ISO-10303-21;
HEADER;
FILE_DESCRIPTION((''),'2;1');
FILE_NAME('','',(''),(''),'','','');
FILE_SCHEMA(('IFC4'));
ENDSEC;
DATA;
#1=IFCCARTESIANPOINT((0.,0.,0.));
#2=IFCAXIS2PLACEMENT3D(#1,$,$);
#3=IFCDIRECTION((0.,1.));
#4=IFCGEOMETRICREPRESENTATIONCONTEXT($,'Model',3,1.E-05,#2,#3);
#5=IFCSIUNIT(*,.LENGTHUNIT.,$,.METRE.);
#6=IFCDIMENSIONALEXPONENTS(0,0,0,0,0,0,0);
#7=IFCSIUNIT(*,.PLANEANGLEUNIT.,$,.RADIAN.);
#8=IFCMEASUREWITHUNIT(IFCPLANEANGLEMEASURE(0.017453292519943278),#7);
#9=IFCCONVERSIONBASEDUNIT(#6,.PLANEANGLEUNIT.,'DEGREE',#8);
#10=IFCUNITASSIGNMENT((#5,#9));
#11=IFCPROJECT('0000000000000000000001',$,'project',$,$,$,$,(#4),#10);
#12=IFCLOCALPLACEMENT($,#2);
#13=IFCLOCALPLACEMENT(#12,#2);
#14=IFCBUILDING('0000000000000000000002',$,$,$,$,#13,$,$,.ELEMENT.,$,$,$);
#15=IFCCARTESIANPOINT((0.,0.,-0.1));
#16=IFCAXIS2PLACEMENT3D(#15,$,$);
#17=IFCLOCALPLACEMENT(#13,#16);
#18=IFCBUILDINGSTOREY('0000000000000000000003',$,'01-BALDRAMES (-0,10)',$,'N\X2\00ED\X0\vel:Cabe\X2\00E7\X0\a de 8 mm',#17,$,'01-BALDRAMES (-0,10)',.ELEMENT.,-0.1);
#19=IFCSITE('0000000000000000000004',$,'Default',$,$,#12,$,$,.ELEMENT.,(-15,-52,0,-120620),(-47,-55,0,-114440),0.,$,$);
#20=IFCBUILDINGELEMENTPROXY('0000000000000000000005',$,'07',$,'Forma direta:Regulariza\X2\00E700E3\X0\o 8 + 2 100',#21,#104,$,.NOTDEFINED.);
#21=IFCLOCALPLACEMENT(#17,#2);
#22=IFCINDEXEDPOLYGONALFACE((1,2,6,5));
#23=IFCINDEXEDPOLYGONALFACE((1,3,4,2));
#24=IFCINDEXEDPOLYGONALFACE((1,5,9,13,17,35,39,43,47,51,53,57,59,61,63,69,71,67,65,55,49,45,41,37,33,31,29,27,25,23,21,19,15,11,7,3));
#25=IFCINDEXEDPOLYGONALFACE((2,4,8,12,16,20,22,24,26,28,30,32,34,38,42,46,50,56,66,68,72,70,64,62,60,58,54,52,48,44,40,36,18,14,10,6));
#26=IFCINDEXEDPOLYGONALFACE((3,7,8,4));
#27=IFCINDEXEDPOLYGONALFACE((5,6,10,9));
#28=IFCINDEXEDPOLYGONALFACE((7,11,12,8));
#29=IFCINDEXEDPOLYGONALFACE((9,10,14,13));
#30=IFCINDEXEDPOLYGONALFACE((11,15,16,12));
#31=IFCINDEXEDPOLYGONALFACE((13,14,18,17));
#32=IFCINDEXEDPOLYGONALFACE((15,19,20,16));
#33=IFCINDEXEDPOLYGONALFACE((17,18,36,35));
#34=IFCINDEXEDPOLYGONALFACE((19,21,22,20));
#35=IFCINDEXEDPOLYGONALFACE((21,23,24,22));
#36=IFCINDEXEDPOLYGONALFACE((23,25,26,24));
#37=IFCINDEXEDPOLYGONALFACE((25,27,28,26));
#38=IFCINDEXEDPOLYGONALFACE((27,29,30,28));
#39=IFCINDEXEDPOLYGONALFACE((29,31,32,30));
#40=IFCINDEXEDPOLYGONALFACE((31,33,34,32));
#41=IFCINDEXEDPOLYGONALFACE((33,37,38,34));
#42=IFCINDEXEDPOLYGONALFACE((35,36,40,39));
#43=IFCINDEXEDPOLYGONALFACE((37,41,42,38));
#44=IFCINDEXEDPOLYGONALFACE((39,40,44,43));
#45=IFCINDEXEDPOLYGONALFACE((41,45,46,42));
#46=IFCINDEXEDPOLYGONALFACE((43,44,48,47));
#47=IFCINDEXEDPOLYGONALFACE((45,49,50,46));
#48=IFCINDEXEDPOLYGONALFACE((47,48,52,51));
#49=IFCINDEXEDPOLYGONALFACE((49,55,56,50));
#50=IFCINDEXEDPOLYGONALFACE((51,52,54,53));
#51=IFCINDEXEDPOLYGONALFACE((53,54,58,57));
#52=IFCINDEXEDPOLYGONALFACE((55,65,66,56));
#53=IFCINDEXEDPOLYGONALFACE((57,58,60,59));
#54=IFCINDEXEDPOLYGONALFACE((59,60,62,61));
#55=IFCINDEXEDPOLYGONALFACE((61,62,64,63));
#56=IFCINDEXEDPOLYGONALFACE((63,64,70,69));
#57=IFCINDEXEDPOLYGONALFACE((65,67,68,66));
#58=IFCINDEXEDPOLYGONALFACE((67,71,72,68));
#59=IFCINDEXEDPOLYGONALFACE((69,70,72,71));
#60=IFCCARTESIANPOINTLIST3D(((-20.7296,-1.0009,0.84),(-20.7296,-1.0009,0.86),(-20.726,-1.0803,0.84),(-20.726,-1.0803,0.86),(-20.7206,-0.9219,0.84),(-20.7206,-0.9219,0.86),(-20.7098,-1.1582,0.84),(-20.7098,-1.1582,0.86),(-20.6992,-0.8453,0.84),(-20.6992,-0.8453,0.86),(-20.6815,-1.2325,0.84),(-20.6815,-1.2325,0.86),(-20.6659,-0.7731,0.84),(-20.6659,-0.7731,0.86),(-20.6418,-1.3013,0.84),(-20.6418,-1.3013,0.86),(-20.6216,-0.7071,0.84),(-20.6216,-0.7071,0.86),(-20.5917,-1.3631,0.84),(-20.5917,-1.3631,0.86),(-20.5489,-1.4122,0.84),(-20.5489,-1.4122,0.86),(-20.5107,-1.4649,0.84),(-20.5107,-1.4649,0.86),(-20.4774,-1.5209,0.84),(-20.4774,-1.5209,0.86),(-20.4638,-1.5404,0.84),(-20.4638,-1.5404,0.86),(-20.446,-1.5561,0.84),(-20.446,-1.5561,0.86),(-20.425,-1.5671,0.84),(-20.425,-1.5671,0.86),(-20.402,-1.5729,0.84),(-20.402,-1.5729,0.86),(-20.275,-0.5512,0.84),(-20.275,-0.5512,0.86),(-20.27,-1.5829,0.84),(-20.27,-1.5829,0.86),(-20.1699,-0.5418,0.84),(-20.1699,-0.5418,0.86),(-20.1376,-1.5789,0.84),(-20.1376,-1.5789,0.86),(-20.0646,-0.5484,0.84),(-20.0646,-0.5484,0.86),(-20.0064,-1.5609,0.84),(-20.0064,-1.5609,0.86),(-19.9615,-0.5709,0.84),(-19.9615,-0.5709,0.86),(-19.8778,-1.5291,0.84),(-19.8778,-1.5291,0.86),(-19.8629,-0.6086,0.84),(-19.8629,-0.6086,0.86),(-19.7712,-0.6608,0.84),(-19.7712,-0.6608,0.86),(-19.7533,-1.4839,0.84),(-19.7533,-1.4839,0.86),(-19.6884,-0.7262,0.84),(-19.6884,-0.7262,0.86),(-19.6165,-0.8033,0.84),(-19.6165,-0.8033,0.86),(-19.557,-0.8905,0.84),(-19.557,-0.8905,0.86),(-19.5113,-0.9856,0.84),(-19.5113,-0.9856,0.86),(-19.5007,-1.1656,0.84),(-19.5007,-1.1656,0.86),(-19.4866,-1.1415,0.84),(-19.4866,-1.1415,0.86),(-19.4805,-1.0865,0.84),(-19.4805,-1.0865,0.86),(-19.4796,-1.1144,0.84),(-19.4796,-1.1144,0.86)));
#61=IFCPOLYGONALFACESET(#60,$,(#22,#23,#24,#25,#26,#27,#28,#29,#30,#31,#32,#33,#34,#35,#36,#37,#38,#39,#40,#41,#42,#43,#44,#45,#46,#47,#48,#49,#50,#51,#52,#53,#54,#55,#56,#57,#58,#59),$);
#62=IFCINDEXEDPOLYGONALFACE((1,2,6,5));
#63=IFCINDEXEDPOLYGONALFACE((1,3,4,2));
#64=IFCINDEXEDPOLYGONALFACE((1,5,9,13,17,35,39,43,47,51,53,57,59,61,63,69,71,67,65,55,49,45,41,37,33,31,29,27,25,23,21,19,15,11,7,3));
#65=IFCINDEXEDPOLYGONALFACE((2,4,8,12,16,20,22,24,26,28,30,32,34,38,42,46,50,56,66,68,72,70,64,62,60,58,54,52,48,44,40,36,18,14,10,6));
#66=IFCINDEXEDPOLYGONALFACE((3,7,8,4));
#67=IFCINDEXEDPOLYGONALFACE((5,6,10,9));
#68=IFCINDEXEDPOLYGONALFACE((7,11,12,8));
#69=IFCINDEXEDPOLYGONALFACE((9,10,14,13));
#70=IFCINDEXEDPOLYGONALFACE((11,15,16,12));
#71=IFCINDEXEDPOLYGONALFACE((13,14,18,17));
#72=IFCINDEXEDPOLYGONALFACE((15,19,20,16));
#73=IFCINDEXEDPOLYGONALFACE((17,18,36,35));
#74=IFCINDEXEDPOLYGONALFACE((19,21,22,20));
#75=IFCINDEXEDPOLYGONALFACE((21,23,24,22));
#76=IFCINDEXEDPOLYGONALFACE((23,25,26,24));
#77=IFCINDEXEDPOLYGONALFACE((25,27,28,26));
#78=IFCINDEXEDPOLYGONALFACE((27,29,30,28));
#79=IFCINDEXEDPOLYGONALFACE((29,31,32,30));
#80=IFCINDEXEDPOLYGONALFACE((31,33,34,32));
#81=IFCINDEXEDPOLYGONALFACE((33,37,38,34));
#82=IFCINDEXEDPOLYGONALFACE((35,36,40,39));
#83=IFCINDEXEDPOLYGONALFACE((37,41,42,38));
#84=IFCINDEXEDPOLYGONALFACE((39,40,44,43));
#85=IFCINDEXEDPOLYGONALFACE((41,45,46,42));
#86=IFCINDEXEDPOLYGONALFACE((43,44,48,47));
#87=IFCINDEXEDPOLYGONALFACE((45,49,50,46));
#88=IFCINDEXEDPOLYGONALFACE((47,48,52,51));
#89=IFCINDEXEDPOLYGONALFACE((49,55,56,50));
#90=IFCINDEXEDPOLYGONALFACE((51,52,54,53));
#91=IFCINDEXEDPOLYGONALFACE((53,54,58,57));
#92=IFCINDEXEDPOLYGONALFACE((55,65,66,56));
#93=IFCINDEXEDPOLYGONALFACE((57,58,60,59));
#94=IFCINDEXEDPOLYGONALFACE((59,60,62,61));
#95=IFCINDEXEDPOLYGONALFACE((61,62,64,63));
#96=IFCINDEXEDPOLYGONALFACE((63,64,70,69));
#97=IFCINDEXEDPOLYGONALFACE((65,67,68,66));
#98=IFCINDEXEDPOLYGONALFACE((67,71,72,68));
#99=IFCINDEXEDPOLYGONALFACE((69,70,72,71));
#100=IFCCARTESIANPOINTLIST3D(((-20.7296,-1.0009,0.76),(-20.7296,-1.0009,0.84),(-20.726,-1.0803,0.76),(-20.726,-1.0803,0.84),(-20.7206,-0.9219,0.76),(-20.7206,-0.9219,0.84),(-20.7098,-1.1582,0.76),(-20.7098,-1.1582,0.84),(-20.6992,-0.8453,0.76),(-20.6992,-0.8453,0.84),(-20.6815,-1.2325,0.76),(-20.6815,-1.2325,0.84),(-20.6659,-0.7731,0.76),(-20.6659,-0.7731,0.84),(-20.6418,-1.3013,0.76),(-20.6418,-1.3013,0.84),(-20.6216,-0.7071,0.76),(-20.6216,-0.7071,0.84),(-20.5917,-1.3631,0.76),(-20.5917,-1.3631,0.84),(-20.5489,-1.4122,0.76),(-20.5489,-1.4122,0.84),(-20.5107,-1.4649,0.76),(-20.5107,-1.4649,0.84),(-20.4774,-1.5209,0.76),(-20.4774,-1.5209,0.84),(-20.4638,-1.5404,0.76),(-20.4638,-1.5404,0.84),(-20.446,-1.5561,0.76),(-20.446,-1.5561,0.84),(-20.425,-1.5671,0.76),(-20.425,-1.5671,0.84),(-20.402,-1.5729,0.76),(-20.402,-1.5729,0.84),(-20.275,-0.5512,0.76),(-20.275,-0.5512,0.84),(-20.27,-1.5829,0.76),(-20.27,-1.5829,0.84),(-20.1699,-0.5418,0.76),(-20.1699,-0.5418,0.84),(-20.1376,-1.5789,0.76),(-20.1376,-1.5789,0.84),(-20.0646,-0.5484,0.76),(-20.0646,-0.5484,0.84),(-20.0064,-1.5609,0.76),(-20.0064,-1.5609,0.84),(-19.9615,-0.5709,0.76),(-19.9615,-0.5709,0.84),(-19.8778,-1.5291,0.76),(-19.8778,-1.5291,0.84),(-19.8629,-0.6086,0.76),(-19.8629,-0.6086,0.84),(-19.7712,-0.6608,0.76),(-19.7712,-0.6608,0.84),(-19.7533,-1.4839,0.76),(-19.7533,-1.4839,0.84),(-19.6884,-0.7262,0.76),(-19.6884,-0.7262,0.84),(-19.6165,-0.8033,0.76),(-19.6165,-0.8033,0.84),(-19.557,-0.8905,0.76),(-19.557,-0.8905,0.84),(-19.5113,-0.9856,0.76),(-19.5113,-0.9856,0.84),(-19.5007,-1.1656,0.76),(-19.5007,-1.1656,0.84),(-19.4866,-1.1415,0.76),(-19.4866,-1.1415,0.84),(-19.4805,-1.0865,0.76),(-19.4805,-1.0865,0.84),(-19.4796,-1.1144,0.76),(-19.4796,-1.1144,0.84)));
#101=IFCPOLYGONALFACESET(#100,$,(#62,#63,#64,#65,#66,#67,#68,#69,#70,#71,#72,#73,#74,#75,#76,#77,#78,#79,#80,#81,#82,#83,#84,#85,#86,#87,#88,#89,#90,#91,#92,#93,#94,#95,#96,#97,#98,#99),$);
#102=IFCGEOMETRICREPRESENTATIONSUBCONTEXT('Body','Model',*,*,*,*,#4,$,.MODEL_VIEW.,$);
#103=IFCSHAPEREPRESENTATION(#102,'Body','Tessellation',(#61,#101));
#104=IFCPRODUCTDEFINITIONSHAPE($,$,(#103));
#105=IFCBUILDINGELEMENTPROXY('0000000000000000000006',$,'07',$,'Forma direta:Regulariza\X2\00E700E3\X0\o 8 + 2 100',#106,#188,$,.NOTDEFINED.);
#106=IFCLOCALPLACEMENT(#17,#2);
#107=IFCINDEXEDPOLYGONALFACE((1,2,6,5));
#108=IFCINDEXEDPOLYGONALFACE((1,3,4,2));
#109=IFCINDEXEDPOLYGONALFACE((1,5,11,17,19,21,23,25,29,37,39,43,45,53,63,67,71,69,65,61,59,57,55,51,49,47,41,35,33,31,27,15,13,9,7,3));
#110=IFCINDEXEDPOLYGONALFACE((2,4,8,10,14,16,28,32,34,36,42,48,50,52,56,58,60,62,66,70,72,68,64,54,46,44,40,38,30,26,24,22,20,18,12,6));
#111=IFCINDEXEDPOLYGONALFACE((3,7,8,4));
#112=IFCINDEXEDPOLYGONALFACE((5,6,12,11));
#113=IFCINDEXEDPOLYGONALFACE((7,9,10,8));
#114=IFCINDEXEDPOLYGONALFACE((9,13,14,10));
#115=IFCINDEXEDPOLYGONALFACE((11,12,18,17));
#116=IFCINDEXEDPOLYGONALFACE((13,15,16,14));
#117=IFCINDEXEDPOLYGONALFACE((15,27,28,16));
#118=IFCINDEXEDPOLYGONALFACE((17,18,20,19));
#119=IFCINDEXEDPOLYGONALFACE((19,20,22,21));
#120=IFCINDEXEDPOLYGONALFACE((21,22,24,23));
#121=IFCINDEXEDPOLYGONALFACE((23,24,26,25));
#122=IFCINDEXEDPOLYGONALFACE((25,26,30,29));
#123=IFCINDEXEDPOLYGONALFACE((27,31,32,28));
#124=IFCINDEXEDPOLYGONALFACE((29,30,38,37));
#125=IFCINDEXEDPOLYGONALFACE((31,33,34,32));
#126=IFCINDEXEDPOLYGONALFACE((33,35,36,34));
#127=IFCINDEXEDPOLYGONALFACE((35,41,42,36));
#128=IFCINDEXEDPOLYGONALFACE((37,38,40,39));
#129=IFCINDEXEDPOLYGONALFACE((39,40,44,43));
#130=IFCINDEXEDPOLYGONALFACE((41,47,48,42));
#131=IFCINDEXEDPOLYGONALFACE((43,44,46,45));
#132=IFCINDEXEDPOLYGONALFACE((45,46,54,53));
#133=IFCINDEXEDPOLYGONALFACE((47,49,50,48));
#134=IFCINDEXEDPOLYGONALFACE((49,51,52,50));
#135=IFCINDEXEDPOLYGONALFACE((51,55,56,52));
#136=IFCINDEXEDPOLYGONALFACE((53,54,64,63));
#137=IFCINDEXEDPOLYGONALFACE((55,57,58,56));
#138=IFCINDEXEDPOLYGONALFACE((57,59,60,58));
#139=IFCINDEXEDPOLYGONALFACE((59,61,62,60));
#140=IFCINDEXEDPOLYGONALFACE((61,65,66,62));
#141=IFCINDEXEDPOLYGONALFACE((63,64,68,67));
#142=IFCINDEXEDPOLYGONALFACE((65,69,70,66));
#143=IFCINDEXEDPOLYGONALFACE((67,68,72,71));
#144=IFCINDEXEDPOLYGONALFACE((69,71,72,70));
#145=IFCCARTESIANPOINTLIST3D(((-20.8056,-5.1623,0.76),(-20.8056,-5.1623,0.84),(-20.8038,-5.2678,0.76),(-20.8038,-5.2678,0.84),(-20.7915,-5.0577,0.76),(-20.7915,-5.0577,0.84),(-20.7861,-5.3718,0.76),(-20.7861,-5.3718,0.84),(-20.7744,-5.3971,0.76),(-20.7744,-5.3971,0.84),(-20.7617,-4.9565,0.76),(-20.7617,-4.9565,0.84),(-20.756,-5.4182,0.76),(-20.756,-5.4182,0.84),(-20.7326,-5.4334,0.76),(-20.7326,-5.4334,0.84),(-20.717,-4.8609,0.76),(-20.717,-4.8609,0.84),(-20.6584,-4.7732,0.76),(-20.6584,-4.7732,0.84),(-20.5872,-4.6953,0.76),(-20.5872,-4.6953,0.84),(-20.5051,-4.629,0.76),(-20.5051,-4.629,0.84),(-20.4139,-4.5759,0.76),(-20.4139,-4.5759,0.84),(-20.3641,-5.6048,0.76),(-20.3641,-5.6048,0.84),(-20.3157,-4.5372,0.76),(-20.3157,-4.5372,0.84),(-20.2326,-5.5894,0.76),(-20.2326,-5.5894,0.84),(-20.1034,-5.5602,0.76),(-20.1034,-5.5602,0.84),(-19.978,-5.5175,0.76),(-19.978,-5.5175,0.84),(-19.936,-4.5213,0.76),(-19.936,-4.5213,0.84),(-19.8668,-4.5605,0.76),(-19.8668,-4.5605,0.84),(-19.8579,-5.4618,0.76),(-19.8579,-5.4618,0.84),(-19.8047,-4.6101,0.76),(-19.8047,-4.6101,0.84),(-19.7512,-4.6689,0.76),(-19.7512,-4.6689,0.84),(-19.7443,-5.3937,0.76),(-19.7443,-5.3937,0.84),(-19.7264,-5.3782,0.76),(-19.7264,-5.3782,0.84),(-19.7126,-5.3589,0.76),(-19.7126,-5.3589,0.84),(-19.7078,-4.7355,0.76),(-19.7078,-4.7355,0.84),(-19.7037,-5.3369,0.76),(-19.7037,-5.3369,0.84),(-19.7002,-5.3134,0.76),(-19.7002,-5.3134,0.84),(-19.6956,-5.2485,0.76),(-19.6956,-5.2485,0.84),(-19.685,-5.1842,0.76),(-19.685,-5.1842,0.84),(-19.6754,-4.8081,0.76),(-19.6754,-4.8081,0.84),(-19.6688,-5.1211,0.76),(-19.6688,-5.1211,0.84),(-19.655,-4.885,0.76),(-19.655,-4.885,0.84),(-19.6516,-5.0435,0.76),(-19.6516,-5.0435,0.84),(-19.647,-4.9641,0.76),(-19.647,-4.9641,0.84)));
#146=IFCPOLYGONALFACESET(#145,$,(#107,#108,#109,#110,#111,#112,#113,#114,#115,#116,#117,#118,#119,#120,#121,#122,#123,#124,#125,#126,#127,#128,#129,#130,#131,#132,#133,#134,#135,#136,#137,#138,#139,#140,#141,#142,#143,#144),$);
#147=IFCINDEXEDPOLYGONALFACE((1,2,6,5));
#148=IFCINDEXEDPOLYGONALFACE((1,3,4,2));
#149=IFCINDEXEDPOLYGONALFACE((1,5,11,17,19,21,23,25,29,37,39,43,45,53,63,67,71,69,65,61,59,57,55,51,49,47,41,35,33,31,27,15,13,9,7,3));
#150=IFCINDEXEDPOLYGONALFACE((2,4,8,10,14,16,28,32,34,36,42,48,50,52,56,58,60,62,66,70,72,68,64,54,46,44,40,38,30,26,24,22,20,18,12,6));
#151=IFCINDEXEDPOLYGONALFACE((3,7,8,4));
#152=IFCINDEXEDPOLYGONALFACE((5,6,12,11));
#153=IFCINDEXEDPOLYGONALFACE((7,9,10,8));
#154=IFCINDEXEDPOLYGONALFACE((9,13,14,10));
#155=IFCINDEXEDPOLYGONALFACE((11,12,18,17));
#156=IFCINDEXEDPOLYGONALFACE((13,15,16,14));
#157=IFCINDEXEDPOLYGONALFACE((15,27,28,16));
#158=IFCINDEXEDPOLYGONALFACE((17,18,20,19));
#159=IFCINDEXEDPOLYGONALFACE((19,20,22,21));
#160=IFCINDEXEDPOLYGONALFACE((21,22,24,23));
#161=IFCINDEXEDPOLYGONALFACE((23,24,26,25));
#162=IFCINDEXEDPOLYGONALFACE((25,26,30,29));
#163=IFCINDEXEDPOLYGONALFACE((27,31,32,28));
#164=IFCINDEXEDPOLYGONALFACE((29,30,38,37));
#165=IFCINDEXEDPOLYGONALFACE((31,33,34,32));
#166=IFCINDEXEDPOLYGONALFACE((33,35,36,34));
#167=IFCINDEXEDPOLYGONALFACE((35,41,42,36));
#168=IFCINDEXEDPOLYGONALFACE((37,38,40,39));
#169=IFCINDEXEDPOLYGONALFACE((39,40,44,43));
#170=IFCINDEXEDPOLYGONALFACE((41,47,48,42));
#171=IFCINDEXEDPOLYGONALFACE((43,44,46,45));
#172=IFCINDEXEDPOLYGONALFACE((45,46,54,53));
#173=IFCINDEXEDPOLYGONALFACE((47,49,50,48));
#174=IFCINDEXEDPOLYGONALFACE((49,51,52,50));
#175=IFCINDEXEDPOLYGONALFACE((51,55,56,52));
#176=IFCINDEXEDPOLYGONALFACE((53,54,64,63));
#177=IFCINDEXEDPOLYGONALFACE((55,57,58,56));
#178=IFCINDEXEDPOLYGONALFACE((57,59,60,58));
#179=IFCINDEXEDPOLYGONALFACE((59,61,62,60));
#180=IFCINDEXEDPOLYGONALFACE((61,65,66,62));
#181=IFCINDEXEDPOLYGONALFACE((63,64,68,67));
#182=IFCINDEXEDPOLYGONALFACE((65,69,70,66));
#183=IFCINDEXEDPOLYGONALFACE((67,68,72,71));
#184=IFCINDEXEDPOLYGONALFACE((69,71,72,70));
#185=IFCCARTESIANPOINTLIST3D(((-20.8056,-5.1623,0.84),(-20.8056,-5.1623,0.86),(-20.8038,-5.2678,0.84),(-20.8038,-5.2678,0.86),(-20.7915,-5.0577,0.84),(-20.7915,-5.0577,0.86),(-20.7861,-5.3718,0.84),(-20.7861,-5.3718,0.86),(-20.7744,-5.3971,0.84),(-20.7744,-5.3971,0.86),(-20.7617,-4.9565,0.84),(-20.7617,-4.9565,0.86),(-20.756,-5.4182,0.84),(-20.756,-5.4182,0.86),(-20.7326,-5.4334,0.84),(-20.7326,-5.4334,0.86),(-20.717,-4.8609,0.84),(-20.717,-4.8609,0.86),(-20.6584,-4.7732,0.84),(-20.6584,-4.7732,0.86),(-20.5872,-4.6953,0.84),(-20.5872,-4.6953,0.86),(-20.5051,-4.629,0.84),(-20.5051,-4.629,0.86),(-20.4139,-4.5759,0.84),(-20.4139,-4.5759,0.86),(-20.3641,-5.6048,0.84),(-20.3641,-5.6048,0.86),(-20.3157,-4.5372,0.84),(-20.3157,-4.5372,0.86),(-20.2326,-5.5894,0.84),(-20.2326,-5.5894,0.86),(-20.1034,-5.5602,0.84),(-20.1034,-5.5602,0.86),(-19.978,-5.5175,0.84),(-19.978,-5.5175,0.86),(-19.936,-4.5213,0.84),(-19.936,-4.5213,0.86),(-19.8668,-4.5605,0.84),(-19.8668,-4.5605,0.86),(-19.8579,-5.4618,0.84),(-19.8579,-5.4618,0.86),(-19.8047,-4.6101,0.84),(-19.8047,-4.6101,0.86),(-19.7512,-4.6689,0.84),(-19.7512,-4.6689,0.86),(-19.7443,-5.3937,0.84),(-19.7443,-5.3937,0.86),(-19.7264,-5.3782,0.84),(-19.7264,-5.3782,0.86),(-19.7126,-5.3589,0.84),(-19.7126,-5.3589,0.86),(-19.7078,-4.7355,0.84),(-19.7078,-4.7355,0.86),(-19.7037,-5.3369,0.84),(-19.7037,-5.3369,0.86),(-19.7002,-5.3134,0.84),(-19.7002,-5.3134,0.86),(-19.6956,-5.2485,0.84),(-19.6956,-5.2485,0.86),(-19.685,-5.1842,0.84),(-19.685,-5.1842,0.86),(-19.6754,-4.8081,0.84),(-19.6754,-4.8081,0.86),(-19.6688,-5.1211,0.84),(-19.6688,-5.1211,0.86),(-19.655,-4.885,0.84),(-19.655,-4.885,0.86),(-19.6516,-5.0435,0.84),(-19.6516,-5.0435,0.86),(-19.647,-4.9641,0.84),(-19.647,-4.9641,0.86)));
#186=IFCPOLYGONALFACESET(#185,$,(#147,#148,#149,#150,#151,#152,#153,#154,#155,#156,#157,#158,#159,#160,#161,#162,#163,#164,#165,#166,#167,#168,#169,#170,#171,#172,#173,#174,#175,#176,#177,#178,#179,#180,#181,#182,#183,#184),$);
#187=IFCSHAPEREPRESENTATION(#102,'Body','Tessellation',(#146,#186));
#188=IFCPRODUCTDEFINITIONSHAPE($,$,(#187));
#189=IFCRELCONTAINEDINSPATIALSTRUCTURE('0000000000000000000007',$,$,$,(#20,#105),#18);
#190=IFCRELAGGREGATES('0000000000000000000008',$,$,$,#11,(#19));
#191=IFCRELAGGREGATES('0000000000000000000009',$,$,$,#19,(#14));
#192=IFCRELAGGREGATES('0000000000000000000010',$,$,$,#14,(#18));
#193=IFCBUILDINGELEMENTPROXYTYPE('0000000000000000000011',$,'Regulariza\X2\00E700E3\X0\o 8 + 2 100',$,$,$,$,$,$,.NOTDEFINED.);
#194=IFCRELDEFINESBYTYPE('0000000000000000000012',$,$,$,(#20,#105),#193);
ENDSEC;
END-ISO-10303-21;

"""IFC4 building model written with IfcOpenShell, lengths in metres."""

from ifc_helpers import new_model, entity, si_unit, converted_unit, direction, frame, origin, place, context, subcontext, project, spatial, line, arc, indexed_curve, outline, extrude, type_object, element, save


model = new_model("IFC4")

# Units and contexts
model_context = context("Model", 3, precision=1e-05, world=origin(), true_north=direction((0.0, 1.0)))
body_context = subcontext(model_context, "Body", "Model", "MODEL_VIEW")
ifc_project = project(units=[si_unit("LENGTHUNIT", "METRE"), converted_unit("PLANEANGLEUNIT", "DEGREE", entity("IfcPlaneAngleMeasure", 0.017453292519943278), si_unit("PLANEANGLEUNIT", "RADIAN"), dimensions=[0, 0, 0, 0, 0, 0, 0])], contexts=[model_context])

# Site, building, storey
site_placement = place(None, origin())
site = spatial("IfcSite", under=ifc_project, at=site_placement, Name="Default", CompositionType="ELEMENT", RefLatitude=(-15, -52, 0, -120620), RefLongitude=(-47, -55, 0, -114440), RefElevation=0.0)
building_placement = place(site_placement, origin())
building = spatial("IfcBuilding", under=site, at=building_placement, CompositionType="ELEMENT")
storey_placement = place(building_placement, frame((0.0, 0.0, -0.1)))
storey = spatial("IfcBuildingStorey", under=building, at=storey_placement, Name="01-BALDRAMES (-0,10)", ObjectType="Nível:Cabeça de 8 mm", LongName="01-BALDRAMES (-0,10)", CompositionType="ELEMENT", Elevation=-0.1)

# Building element proxies
building_element_proxy_type_1 = type_object("IfcBuildingElementProxyType", Name="Regularização 8 + 2 100", PredefinedType="NOTDEFINED")
proxy_1_placement = place(storey_placement, origin())
element("IfcBuildingElementProxy", 1, at=proxy_1_placement, inside=storey, type_object=building_element_proxy_type_1, Name="07", ObjectType="Forma direta:Regularização 8 + 2 100", PredefinedType="NOTDEFINED", context=body_context, shape_type="SweptSolid", body=[
    extrude(outline(indexed_curve([(0.6738, -0.0708), (0.5509, 0.2575), (0.2427, 0.4245), (0.147, 0.4444), (0.055, 0.4771), (0.0086, 0.4851), (-0.0364, 0.4709), (-0.2943, 0.2646), (-0.4892, -0.002), (-0.4892, -0.4084), (-0.4805, -0.4492), (-0.4559, -0.4829), (0.0365, -0.6357), (0.4992, -0.4084)], segments=[arc(1, 2, 3), arc(3, 4, 5), arc(5, 6, 7), arc(7, 8, 9), line(9, 10), arc(10, 11, 12), arc(12, 13, 14), line(14, 1)], self_intersect=False)), frame((-20.1378, -1.1814, 0.84), z_axis=(0.0, 0.0, 1.0), x_axis=(-0.78332, 0.621618, 0.0)), (0.0, 0.0, 1.0), 0.02),
    extrude(outline(indexed_curve([(0.6738, -0.0708), (0.5509, 0.2575), (0.2427, 0.4245), (0.147, 0.4444), (0.055, 0.4771), (0.0086, 0.4851), (-0.0364, 0.4709), (-0.2943, 0.2646), (-0.4892, -0.002), (-0.4892, -0.4084), (-0.4805, -0.4492), (-0.4559, -0.4829), (0.0365, -0.6357), (0.4992, -0.4084)], segments=[arc(1, 2, 3), arc(3, 4, 5), arc(5, 6, 7), arc(7, 8, 9), line(9, 10), arc(10, 11, 12), arc(12, 13, 14), line(14, 1)], self_intersect=False)), frame((-20.1378, -1.1814, 0.76), z_axis=(0.0, 0.0, 1.0), x_axis=(-0.78332, 0.621618, 0.0)), (0.0, 0.0, 1.0), 0.08),
])
proxy_2_placement = place(storey_placement, origin())
element("IfcBuildingElementProxy", 2, at=proxy_2_placement, inside=storey, type_object=building_element_proxy_type_1, Name="07", ObjectType="Forma direta:Regularização 8 + 2 100", PredefinedType="NOTDEFINED", context=body_context, shape_type="SweptSolid", body=[
    extrude(outline(indexed_curve([(0.6639, 0.0179), (0.6551, 0.0588), (0.6305, 0.0925), (0.3276, 0.3633), (-0.0011, 0.3957), (-0.3268, 0.341), (-0.3673, 0.3169), (-0.3923, 0.277), (-0.4293, 0.1866), (-0.4782, 0.102), (-0.5592, -0.239), (-0.3964, -0.5495), (-0.0283, -0.6444), (0.4495, -0.4509)], segments=[arc(1, 2, 3), line(3, 4), arc(4, 5, 6), arc(6, 7, 8), arc(8, 9, 10), arc(10, 11, 12), line(12, 13), arc(13, 14, 1)], self_intersect=False)), frame((-20.156, -5.1621, 0.76), z_axis=(0.0, 0.0, 1.0), x_axis=(-0.957025, -0.290006, 0.0)), (0.0, 0.0, 1.0), 0.08),
    extrude(outline(indexed_curve([(0.6639, 0.0179), (0.6551, 0.0588), (0.6305, 0.0925), (0.3276, 0.3633), (-0.0011, 0.3957), (-0.3268, 0.341), (-0.3673, 0.3169), (-0.3923, 0.277), (-0.4293, 0.1866), (-0.4782, 0.102), (-0.5592, -0.239), (-0.3964, -0.5495), (-0.0283, -0.6444), (0.4495, -0.4509)], segments=[arc(1, 2, 3), line(3, 4), arc(4, 5, 6), arc(6, 7, 8), arc(8, 9, 10), arc(10, 11, 12), line(12, 13), arc(13, 14, 1)], self_intersect=False)), frame((-20.156, -5.1621, 0.84), z_axis=(0.0, 0.0, 1.0), x_axis=(-0.957025, -0.290006, 0.0)), (0.0, 0.0, 1.0), 0.02),
])

save(model, "model.ifc")
